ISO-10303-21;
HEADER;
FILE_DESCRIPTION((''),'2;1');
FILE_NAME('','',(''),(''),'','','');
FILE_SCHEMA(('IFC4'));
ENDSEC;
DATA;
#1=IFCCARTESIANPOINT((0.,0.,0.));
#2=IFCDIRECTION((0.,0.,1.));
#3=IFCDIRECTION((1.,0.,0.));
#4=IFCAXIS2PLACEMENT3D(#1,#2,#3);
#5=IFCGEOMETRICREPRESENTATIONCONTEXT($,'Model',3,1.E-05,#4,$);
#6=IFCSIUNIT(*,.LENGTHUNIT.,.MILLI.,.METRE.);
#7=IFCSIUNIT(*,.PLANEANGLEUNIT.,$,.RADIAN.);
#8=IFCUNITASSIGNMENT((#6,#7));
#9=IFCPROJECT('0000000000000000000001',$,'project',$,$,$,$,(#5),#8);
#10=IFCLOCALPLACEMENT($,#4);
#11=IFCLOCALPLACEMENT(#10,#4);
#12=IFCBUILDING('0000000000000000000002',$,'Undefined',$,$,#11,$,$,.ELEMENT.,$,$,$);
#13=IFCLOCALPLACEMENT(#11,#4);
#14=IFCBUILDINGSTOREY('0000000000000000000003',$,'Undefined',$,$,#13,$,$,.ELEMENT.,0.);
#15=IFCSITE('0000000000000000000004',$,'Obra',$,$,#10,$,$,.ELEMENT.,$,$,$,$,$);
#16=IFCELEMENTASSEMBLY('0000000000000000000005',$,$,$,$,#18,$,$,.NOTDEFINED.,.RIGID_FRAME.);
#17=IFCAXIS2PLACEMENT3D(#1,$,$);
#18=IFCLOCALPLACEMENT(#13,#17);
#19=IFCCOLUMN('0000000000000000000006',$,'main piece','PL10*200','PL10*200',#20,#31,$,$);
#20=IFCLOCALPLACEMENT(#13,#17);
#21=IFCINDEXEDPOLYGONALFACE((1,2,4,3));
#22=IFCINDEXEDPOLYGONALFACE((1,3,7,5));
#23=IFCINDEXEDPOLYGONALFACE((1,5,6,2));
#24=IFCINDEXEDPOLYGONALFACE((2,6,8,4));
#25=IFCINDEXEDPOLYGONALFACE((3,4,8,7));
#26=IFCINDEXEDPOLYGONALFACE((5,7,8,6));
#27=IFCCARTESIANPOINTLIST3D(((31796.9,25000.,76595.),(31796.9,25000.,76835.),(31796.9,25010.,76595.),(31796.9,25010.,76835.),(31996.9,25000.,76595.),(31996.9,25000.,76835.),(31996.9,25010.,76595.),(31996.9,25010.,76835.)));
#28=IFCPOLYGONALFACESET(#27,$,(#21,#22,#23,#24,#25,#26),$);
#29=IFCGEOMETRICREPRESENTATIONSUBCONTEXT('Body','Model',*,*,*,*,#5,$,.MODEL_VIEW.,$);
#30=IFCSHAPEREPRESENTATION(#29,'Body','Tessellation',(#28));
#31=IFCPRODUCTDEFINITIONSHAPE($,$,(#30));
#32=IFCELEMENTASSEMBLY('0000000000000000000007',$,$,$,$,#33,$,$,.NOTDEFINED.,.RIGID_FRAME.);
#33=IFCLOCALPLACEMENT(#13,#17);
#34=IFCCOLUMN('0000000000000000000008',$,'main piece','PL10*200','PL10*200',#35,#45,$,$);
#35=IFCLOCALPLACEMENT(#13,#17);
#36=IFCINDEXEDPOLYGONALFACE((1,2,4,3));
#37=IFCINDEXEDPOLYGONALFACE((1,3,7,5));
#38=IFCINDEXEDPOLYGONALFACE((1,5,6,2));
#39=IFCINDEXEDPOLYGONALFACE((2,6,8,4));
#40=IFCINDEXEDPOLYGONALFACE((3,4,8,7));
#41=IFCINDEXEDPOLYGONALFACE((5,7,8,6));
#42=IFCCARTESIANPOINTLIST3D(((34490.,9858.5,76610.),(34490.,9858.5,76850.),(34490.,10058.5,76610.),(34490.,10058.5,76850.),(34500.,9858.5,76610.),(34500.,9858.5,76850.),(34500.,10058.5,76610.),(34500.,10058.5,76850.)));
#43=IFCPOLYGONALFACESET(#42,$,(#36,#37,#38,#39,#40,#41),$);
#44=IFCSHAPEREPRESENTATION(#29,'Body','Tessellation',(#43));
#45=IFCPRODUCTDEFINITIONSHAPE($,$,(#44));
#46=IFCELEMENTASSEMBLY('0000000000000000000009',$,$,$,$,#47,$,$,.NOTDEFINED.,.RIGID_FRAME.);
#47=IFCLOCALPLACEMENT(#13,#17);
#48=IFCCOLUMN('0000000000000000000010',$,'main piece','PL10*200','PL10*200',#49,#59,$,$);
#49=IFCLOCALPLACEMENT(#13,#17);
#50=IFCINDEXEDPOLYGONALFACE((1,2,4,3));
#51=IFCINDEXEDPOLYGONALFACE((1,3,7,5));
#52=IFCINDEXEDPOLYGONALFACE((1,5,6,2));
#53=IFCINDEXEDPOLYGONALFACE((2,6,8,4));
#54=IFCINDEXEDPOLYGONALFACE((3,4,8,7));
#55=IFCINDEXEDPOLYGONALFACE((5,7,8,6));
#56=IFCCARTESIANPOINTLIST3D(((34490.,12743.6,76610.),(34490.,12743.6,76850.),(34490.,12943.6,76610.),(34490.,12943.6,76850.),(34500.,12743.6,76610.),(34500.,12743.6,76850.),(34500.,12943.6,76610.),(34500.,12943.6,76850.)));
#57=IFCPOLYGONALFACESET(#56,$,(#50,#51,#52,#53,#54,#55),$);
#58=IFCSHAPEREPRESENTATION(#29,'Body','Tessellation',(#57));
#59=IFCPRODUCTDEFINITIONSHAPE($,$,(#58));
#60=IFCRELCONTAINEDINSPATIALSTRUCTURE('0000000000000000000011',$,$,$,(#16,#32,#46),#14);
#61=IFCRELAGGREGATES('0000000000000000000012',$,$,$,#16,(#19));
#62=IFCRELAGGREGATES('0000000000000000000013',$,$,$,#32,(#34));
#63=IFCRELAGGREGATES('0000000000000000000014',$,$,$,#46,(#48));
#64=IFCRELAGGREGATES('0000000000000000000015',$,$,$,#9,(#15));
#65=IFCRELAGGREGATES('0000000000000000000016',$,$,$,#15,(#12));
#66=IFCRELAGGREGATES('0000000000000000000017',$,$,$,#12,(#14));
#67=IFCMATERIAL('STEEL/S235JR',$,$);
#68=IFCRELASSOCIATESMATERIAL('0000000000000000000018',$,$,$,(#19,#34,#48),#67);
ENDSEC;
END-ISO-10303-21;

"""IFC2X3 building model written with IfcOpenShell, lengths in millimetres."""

from ifc_helpers import new_model, si_unit, frame, origin_with_axes, origin_2d_with_axis, place, context, subcontext, project, spatial, rectangle, extrude, material, element, aggregate, save


model = new_model("IFC2X3")

# Units and contexts
model_context = context("Model", 3, precision=1e-05, world=origin_with_axes())
body_context = subcontext(model_context, "Body", "Model", "MODEL_VIEW")
ifc_project = project(units=[si_unit("LENGTHUNIT", "METRE", prefix="MILLI"), si_unit("PLANEANGLEUNIT", "RADIAN")], contexts=[model_context])

# Site, building, storey
site_placement = place(None, origin_with_axes())
site = spatial("IfcSite", under=ifc_project, at=site_placement, Name="Obra", CompositionType="ELEMENT")
building_placement = place(site_placement, origin_with_axes())
building = spatial("IfcBuilding", under=site, at=building_placement, Name="Undefined", CompositionType="ELEMENT")
storey_placement = place(building_placement, origin_with_axes())
storey = spatial("IfcBuildingStorey", under=building, at=storey_placement, Name="Undefined", CompositionType="ELEMENT", Elevation=0.0)

# Element assemblies, columns
assembly_1_placement = place(storey_placement, origin_with_axes())
assembly_1 = element("IfcElementAssembly", 1, at=assembly_1_placement, inside=storey, AssemblyPlace="NOTDEFINED", PredefinedType="RIGID_FRAME")
ifc_material = material(Name="STEEL/S235JR")
column_1_placement = place(assembly_1_placement, frame((31896.9, 25005.0, 76595.0), z_axis=(0.0, 0.0, 1.0), x_axis=(-1.0, -0.000002, 0.0)))
column_1 = element("IfcColumn", 2, at=column_1_placement, material=ifc_material, Name="main piece", Description="PL10*200", ObjectType="PL10*200", context=body_context, shape_type="SweptSolid", body=[
    extrude(rectangle(XDim=10.0, YDim=200.0, at=origin_2d_with_axis()), frame((0.0, 0.0, 240.0), z_axis=(0.0, 0.0, -1.0), x_axis=(0.0, 1.0, 0.0)), (0.0, 0.0, 1.0), 240.0),
])
assembly_2_placement = place(storey_placement, origin_with_axes())
assembly_2 = element("IfcElementAssembly", 3, at=assembly_2_placement, inside=storey, AssemblyPlace="NOTDEFINED", PredefinedType="RIGID_FRAME")
column_2_placement = place(assembly_2_placement, frame((34495.0, 9958.5, 76610.0), z_axis=(0.0, 0.0, 1.0), x_axis=(0.0, -1.0, 0.0)))
column_2 = element("IfcColumn", 4, at=column_2_placement, material=ifc_material, Name="main piece", Description="PL10*200", ObjectType="PL10*200", context=body_context, shape_type="SweptSolid", body=[
    extrude(rectangle(XDim=10.0, YDim=200.0, at=origin_2d_with_axis()), frame((0.0, 0.0, 240.0), z_axis=(0.0, 0.0, -1.0), x_axis=(0.0, 1.0, 0.0)), (0.0, 0.0, 1.0), 240.0),
])
assembly_3_placement = place(storey_placement, origin_with_axes())
assembly_3 = element("IfcElementAssembly", 5, at=assembly_3_placement, inside=storey, AssemblyPlace="NOTDEFINED", PredefinedType="RIGID_FRAME")
column_3_placement = place(assembly_3_placement, frame((34495.0, 12843.6, 76610.0), z_axis=(0.0, 0.0, 1.0), x_axis=(0.0, -1.0, 0.0)))
column_3 = element("IfcColumn", 6, at=column_3_placement, material=ifc_material, Name="main piece", Description="PL10*200", ObjectType="PL10*200", context=body_context, shape_type="SweptSolid", body=[
    extrude(rectangle(XDim=10.0, YDim=200.0, at=origin_2d_with_axis()), frame((0.0, 0.0, 240.0), z_axis=(0.0, 0.0, -1.0), x_axis=(0.0, 1.0, 0.0)), (0.0, 0.0, 1.0), 240.0),
])

aggregate(assembly_1, [column_1])

aggregate(assembly_2, [column_2])
aggregate(assembly_3, [column_3])

save(model, "model.ifc")
